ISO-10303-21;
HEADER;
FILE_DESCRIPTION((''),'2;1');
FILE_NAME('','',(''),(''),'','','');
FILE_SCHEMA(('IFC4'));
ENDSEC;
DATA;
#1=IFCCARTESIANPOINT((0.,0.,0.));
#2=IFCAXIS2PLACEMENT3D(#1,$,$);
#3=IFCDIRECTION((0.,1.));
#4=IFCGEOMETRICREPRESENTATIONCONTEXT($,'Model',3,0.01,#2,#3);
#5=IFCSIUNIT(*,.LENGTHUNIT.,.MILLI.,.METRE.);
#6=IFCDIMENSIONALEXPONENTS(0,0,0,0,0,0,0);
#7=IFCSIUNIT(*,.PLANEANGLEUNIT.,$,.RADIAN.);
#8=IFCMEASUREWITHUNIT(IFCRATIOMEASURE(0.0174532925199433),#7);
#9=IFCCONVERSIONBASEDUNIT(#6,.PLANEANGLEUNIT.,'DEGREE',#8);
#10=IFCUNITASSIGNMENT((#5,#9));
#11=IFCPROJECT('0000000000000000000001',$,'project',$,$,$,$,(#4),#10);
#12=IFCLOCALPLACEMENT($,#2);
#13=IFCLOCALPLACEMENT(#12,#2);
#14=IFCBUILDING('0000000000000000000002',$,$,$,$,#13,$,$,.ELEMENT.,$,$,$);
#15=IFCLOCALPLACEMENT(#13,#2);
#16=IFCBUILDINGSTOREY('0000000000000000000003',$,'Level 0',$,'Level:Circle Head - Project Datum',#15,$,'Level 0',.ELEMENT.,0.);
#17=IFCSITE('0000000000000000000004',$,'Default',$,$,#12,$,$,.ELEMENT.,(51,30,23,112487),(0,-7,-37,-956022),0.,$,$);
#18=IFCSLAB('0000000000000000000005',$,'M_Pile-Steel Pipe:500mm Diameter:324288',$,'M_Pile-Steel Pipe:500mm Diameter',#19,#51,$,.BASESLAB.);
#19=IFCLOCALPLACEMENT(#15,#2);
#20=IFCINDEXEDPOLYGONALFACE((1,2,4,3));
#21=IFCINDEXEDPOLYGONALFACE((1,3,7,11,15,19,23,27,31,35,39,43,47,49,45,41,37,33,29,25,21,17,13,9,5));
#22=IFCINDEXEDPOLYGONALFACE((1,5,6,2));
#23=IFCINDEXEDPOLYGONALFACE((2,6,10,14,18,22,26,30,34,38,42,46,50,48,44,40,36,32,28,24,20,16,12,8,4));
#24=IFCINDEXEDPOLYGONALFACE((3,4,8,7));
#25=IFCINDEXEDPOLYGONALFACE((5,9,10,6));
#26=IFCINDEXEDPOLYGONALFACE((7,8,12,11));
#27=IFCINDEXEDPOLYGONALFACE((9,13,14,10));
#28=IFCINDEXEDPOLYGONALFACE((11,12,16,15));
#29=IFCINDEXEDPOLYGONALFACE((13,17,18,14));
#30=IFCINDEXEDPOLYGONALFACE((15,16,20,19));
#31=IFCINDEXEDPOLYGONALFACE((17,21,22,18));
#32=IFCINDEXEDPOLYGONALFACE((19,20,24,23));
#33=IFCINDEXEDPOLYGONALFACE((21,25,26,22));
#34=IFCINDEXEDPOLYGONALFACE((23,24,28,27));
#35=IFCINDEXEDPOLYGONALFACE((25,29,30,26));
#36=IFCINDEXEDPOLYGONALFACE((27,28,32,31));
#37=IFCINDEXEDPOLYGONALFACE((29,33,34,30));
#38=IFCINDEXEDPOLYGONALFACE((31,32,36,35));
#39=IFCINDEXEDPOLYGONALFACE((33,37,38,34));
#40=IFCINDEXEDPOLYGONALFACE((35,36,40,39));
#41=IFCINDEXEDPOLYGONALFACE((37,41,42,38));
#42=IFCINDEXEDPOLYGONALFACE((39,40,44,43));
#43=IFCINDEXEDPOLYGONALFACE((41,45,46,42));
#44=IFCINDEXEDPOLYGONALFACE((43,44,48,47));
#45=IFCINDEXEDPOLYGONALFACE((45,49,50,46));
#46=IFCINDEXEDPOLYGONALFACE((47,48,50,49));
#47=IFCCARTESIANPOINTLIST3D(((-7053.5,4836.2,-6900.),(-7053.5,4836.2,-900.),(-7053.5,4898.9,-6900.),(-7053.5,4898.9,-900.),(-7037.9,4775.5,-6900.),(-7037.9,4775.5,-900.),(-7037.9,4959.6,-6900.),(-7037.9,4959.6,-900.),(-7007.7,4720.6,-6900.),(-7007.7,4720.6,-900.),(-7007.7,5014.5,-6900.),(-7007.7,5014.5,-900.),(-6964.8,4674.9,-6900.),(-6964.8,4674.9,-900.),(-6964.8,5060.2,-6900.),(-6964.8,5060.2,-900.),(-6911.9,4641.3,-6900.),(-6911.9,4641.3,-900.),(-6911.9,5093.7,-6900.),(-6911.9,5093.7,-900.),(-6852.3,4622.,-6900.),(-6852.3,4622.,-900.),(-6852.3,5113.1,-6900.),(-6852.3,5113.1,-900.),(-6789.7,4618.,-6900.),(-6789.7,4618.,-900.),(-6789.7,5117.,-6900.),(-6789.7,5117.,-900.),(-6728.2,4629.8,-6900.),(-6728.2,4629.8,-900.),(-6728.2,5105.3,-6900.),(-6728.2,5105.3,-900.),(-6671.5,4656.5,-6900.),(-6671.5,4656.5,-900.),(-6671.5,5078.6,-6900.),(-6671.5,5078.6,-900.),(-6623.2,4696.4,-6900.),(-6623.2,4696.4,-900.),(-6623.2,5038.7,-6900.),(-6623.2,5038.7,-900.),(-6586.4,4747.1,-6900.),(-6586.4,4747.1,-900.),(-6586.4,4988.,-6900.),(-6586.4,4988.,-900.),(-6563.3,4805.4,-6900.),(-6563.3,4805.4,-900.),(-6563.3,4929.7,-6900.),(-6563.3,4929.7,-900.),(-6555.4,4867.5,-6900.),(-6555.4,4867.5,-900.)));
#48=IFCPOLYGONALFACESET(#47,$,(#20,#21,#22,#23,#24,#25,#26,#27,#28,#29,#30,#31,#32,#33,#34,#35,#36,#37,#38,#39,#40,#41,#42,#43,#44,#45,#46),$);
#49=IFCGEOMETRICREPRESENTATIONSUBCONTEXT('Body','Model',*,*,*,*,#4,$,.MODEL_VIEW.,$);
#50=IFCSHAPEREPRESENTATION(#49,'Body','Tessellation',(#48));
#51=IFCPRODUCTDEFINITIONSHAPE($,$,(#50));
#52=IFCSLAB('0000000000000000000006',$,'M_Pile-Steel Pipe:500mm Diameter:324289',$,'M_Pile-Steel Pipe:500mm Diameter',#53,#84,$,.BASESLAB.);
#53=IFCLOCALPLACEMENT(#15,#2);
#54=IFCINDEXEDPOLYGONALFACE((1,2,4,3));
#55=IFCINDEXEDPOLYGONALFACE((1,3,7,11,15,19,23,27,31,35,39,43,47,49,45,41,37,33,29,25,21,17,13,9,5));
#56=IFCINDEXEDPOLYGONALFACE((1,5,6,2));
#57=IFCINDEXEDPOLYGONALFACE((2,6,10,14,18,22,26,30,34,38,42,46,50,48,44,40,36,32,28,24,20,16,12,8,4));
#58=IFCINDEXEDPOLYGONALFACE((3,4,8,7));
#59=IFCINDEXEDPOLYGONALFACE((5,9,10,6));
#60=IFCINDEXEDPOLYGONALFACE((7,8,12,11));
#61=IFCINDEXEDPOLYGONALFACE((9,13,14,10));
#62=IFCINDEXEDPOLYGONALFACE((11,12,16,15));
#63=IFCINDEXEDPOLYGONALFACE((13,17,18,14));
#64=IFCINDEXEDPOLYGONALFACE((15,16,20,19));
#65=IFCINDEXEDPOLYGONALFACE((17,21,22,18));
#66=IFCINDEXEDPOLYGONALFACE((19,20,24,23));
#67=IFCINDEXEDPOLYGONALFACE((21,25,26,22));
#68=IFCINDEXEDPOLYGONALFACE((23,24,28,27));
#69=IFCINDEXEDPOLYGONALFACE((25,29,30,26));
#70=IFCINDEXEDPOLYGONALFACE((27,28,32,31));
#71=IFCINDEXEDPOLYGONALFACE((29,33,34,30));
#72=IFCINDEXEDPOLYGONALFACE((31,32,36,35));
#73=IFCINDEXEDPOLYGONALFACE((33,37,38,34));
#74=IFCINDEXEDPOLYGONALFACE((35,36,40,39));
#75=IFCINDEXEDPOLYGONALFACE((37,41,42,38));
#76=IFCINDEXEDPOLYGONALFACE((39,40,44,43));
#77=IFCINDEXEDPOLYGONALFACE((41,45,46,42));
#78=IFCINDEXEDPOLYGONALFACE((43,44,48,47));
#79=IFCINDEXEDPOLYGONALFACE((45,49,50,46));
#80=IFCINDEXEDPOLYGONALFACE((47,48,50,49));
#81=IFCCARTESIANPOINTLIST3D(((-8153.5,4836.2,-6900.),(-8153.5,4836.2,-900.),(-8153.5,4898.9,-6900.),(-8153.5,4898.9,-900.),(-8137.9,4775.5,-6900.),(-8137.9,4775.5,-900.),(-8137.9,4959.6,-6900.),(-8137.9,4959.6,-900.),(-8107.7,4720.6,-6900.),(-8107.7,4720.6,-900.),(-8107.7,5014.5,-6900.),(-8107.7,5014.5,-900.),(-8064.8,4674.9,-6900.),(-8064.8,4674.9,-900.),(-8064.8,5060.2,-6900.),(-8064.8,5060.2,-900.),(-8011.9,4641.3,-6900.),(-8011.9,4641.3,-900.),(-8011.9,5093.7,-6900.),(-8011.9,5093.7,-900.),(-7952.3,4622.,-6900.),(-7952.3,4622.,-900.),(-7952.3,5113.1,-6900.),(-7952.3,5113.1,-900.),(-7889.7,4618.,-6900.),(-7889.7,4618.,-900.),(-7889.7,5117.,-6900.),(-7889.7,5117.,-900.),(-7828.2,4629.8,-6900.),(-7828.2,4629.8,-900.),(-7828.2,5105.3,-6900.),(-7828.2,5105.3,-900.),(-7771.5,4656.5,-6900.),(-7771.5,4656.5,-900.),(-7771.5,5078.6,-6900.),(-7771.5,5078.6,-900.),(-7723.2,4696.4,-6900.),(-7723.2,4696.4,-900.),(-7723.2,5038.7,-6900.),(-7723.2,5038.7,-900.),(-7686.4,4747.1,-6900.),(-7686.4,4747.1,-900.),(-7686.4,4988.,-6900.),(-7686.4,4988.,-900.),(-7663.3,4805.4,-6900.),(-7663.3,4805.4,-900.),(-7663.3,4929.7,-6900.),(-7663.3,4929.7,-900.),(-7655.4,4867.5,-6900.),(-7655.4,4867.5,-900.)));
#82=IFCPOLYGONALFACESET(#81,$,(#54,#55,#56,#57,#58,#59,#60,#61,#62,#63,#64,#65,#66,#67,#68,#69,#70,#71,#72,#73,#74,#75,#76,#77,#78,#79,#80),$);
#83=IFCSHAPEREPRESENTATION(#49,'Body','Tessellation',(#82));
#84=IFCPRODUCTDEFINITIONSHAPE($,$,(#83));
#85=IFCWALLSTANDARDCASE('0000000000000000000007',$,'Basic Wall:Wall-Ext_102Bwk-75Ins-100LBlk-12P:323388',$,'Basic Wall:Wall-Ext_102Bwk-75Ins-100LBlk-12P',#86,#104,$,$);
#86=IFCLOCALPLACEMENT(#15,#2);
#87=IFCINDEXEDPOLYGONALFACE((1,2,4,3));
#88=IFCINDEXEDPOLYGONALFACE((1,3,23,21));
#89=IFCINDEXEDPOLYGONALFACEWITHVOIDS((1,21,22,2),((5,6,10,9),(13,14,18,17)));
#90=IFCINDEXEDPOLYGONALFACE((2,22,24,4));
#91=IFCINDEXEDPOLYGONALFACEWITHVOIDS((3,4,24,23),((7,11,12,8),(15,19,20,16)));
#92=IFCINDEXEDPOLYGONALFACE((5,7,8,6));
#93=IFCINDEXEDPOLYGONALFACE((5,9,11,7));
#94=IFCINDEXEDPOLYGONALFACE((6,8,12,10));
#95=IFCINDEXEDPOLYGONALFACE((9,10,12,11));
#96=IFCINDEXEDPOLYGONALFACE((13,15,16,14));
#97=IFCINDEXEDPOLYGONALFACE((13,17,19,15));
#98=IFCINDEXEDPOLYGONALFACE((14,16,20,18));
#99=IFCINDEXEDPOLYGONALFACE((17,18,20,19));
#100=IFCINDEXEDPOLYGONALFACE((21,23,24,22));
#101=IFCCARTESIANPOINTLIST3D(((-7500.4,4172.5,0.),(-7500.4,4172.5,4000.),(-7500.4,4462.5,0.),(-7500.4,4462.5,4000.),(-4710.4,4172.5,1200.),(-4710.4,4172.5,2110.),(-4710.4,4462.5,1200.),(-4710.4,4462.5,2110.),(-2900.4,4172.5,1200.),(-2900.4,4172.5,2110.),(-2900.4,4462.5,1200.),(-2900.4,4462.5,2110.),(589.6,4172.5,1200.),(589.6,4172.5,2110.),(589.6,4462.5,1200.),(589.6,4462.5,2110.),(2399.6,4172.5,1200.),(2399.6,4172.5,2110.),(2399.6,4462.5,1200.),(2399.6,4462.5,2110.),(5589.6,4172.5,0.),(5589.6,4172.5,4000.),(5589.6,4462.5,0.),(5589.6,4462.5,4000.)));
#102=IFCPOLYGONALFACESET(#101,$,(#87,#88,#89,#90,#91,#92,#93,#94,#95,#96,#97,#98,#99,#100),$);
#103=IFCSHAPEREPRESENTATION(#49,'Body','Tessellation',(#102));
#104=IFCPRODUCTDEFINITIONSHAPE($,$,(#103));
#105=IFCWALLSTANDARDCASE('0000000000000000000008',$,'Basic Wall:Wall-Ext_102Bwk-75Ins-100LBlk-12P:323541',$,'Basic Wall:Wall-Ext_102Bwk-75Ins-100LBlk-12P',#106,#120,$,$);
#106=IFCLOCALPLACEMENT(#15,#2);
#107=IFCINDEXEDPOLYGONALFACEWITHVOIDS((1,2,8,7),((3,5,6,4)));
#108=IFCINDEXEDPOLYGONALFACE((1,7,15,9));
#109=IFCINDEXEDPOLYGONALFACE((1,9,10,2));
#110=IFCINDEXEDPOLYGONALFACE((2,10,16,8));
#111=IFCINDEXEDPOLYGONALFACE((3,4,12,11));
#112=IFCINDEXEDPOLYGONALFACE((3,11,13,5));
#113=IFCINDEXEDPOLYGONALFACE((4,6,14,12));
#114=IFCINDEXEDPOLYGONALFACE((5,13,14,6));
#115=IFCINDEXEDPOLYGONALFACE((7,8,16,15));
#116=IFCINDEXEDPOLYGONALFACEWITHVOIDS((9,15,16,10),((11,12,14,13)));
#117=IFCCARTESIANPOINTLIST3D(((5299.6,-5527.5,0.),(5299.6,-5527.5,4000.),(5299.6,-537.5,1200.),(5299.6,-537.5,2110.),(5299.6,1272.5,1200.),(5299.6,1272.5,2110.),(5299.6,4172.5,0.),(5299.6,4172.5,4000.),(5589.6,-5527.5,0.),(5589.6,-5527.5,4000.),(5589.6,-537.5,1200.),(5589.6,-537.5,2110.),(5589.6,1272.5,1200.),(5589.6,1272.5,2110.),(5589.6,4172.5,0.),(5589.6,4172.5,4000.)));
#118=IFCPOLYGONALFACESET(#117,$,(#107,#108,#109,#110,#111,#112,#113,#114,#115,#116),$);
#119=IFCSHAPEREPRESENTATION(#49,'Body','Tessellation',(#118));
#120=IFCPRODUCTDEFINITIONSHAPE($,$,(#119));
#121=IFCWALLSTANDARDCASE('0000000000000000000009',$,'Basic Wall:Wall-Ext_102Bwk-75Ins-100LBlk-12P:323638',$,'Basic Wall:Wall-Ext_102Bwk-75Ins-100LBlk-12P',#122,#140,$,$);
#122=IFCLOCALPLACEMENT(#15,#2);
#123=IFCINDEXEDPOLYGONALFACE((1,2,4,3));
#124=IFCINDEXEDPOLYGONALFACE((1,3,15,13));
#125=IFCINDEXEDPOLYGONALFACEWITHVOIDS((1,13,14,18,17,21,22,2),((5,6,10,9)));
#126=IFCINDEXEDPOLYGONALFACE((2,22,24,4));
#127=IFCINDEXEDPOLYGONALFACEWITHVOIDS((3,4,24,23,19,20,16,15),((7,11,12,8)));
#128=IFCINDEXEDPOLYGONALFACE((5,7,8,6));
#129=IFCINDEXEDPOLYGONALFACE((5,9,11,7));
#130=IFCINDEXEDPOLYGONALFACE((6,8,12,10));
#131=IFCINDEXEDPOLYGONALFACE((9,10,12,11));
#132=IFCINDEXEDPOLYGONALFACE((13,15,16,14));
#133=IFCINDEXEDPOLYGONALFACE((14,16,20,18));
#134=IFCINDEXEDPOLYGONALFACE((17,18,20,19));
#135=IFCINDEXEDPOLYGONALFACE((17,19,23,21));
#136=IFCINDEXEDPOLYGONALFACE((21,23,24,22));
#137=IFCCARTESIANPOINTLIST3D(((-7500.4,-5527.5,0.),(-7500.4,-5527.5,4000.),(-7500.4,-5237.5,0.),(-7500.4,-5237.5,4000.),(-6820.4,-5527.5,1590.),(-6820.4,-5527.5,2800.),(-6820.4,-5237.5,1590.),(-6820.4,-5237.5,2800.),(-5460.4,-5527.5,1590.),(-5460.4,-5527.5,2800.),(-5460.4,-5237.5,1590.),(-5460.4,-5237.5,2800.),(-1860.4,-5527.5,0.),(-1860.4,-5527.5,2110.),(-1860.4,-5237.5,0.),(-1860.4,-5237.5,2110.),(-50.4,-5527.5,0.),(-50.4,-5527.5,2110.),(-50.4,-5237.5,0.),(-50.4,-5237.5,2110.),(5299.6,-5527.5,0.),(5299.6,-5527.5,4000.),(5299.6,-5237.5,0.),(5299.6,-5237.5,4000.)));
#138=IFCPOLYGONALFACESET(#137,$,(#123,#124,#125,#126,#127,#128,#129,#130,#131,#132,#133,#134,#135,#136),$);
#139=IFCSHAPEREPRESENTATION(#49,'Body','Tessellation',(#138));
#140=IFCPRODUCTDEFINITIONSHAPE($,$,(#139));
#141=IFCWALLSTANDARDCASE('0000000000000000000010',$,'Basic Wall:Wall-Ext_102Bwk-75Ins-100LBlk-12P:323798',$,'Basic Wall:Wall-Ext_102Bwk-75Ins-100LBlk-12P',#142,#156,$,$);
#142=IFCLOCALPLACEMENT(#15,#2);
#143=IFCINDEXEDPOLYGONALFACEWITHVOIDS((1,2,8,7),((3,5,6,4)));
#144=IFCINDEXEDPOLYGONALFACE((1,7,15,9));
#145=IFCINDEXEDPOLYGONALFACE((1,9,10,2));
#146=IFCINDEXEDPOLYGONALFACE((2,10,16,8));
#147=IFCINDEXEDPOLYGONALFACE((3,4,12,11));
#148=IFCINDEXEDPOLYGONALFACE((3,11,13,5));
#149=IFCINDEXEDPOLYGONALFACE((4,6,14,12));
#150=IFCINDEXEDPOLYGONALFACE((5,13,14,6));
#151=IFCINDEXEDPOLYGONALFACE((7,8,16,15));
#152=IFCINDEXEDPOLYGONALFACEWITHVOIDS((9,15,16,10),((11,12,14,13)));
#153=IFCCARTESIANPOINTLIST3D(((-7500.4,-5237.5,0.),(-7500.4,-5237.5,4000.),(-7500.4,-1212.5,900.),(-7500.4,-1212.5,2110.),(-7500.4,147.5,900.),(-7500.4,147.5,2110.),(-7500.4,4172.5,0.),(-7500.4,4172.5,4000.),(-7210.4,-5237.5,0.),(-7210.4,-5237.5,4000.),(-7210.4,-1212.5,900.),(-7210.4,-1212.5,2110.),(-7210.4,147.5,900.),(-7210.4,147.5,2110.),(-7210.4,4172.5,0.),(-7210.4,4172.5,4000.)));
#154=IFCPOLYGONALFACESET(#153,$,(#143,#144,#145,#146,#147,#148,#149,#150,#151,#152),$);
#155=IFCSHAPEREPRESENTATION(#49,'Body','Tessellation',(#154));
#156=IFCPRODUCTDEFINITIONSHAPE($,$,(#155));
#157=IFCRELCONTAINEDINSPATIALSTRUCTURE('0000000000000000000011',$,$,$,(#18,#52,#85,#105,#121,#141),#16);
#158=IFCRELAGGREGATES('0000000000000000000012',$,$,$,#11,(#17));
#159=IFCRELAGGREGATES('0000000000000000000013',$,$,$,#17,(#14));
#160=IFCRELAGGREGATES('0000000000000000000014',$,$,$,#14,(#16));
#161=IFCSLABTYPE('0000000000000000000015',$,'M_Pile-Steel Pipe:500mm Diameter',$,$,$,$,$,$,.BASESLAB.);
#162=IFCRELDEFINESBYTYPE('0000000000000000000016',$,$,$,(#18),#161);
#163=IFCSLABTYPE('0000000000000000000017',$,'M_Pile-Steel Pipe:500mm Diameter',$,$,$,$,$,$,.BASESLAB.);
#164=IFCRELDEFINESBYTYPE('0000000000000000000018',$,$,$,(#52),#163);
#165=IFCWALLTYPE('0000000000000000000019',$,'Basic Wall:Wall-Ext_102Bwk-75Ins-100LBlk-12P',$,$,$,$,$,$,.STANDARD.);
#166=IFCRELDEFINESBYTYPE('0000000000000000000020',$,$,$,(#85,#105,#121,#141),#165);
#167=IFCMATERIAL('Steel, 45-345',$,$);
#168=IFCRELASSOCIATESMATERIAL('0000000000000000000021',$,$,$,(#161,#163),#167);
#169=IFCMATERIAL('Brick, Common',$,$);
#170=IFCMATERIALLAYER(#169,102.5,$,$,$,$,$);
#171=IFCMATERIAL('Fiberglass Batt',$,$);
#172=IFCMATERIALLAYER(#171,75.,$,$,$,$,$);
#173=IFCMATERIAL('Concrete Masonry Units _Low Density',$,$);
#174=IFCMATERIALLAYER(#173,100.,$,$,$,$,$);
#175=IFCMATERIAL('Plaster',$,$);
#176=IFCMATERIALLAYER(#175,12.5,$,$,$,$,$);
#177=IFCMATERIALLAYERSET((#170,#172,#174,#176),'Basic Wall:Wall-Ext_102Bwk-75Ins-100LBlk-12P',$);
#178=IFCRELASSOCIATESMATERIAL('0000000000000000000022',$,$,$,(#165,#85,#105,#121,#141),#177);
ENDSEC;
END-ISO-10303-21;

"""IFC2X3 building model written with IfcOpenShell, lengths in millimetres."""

from ifc_helpers import new_model, entity, si_unit, converted_unit, direction, frame, frame_2d, origin, place, context, subcontext, project, spatial, rectangle, circle, extrude, material, layer, layer_set, layer_usage, type_object, element, save


model = new_model("IFC2X3")

# Units and contexts
model_context = context("Model", 3, precision=0.01, world=origin(), true_north=direction((0.0, 1.0)))
body_context = subcontext(model_context, "Body", "Model", "MODEL_VIEW")
ifc_project = project(units=[si_unit("LENGTHUNIT", "METRE", prefix="MILLI"), converted_unit("PLANEANGLEUNIT", "DEGREE", entity("IfcRatioMeasure", 0.0174532925199433), si_unit("PLANEANGLEUNIT", "RADIAN"), dimensions=[0, 0, 0, 0, 0, 0, 0])], contexts=[model_context])

# Site, building, storey
site_placement = place(None, origin())
site = spatial("IfcSite", under=ifc_project, at=site_placement, Name="Default", CompositionType="ELEMENT", RefLatitude=(51, 30, 23, 112487), RefLongitude=(0, -7, -37, -956022), RefElevation=0.0)
building_placement = place(site_placement, origin())
building = spatial("IfcBuilding", under=site, at=building_placement, CompositionType="ELEMENT")
storey_placement = place(building_placement, origin())
storey = spatial("IfcBuildingStorey", under=building, at=storey_placement, Name="Level 0", ObjectType="Level:Circle Head - Project Datum", LongName="Level 0", CompositionType="ELEMENT", Elevation=0.0)

# Slabs
ifc_material_1 = material(Name="Steel, 45-345")
slab_type_1 = type_object("IfcSlabType", Name="M_Pile-Steel Pipe:500mm Diameter", PredefinedType="BASESLAB", material=ifc_material_1)
slab_1_placement = place(storey_placement, origin())
element("IfcSlab", 1, at=slab_1_placement, inside=storey, type_object=slab_type_1, Name="M_Pile-Steel Pipe:500mm Diameter:324288", ObjectType="M_Pile-Steel Pipe:500mm Diameter", PredefinedType="BASESLAB", context=body_context, shape_type="SweptSolid", body=[
    extrude(circle(Radius=250.0, at=frame_2d((0.0, 0.0), x_axis=(1.0, 0.0))), frame((-6805.4, 4867.5, -6900.0)), (0.0, 0.0, 1.0), 6000.0),
])
slab_type_2 = type_object("IfcSlabType", Name="M_Pile-Steel Pipe:500mm Diameter", PredefinedType="BASESLAB", material=ifc_material_1)
slab_2_placement = place(storey_placement, origin())
element("IfcSlab", 2, at=slab_2_placement, inside=storey, type_object=slab_type_2, Name="M_Pile-Steel Pipe:500mm Diameter:324289", ObjectType="M_Pile-Steel Pipe:500mm Diameter", PredefinedType="BASESLAB", context=body_context, shape_type="SweptSolid", body=[
    extrude(circle(Radius=250.0, at=frame_2d((0.0, 0.0), x_axis=(1.0, 0.0))), frame((-7905.4, 4867.5, -6900.0)), (0.0, 0.0, 1.0), 6000.0),
])

# Wall, openings
ifc_material_2 = material(Name="Brick, Common")
ifc_layer_1 = layer(ifc_material_2, 102.5)
ifc_material_3 = material(Name="Fiberglass Batt")
ifc_layer_2 = layer(ifc_material_3, 75.0)
ifc_material_4 = material(Name="Concrete Masonry Units _Low Density")
ifc_layer_3 = layer(ifc_material_4, 100.0)
ifc_material_5 = material(Name="Plaster")
ifc_layer_4 = layer(ifc_material_5, 12.5)
ifc_layer_set_1 = layer_set([ifc_layer_1, ifc_layer_2, ifc_layer_3, ifc_layer_4], Name="Basic Wall:Wall-Ext_102Bwk-75Ins-100LBlk-12P")
ifc_layer_usage_1 = layer_usage(ifc_layer_set_1, "AXIS2", "NEGATIVE", 145.0)
wall_type = type_object("IfcWallType", Name="Basic Wall:Wall-Ext_102Bwk-75Ins-100LBlk-12P", PredefinedType="STANDARD", material=ifc_layer_set_1)
wall_1_placement = place(storey_placement, frame((-7500.4, 4317.5, 0.0)))
wall_1 = element("IfcWallStandardCase", 3, at=wall_1_placement, inside=storey, type_object=wall_type, material=ifc_layer_usage_1, Name="Basic Wall:Wall-Ext_102Bwk-75Ins-100LBlk-12P:323388", ObjectType="Basic Wall:Wall-Ext_102Bwk-75Ins-100LBlk-12P", context=body_context, shape_type="SweptSolid", body=[
    extrude(rectangle(XDim=13090.0, YDim=290.0, at=frame_2d((6545.0, 0.0), x_axis=(-1.0, 0.0))), origin(), (0.0, 0.0, 1.0), 4000.0),
])
opening_1_placement = place(wall_1_placement, frame((2790.0, -145.0, 1200.0)))
element("IfcOpeningElement", 4, at=opening_1_placement, cuts=wall_1, ObjectType="Opening", context=body_context, shape_type="SweptSolid", body=[
    extrude(rectangle(XDim=910.0, YDim=1810.0, at=frame_2d((455.0, 905.0), x_axis=(-1.0, 0.0))), frame((0.0, 0.0, 0.0), z_axis=(0.0, 1.0, 0.0), x_axis=(0.0, 0.0, 1.0)), (0.0, 0.0, 1.0), 290.0),
])
opening_2_placement = place(wall_1_placement, frame((8090.0, -145.0, 1200.0)))
element("IfcOpeningElement", 5, at=opening_2_placement, cuts=wall_1, ObjectType="Opening", context=body_context, shape_type="SweptSolid", body=[
    extrude(rectangle(XDim=910.0, YDim=1810.0, at=frame_2d((455.0, 905.0), x_axis=(-1.0, 0.0))), frame((0.0, 0.0, 0.0), z_axis=(0.0, 1.0, 0.0), x_axis=(0.0, 0.0, 1.0)), (0.0, 0.0, 1.0), 290.0),
])

# Wall, opening
ifc_layer_usage_2 = layer_usage(ifc_layer_set_1, "AXIS2", "NEGATIVE", 145.0)
wall_2_placement = place(storey_placement, frame((5444.6, 4172.5, 0.0), z_axis=(0.0, 0.0, 1.0), x_axis=(0.0, -1.0, 0.0)))
wall_2 = element("IfcWallStandardCase", 6, at=wall_2_placement, inside=storey, type_object=wall_type, material=ifc_layer_usage_2, Name="Basic Wall:Wall-Ext_102Bwk-75Ins-100LBlk-12P:323541", ObjectType="Basic Wall:Wall-Ext_102Bwk-75Ins-100LBlk-12P", context=body_context, shape_type="SweptSolid", body=[
    extrude(rectangle(XDim=9700.0, YDim=290.0, at=frame_2d((4850.0, 0.0), x_axis=(-1.0, 0.0))), origin(), (0.0, 0.0, 1.0), 4000.0),
])
opening_3_placement = place(wall_2_placement, frame((2900.0, -145.0, 1200.0)))
element("IfcOpeningElement", 7, at=opening_3_placement, cuts=wall_2, ObjectType="Opening", context=body_context, shape_type="SweptSolid", body=[
    extrude(rectangle(XDim=910.0, YDim=1810.0, at=frame_2d((455.0, 905.0), x_axis=(-1.0, 0.0))), frame((0.0, 0.0, 0.0), z_axis=(0.0, 1.0, 0.0), x_axis=(0.0, 0.0, 1.0)), (0.0, 0.0, 1.0), 290.0),
])

# Wall, openings
ifc_layer_usage_3 = layer_usage(ifc_layer_set_1, "AXIS2", "NEGATIVE", 145.0)
wall_3_placement = place(storey_placement, frame((5299.6, -5382.5, 0.0), z_axis=(0.0, 0.0, 1.0), x_axis=(-1.0, 0.0, 0.0)))
wall_3 = element("IfcWallStandardCase", 8, at=wall_3_placement, inside=storey, type_object=wall_type, material=ifc_layer_usage_3, Name="Basic Wall:Wall-Ext_102Bwk-75Ins-100LBlk-12P:323638", ObjectType="Basic Wall:Wall-Ext_102Bwk-75Ins-100LBlk-12P", context=body_context, shape_type="SweptSolid", body=[
    extrude(rectangle(XDim=12800.0, YDim=290.0, at=frame_2d((6400.0, 0.0), x_axis=(-1.0, 0.0))), origin(), (0.0, 0.0, 1.0), 4000.0),
])
opening_4_placement = place(wall_3_placement, frame((7160.0, 145.0, 0.0)))
element("IfcOpeningElement", 9, at=opening_4_placement, cuts=wall_3, ObjectType="Opening", context=body_context, shape_type="SweptSolid", body=[
    extrude(rectangle(XDim=2110.0, YDim=1810.0, at=frame_2d((1055.0, 905.0), x_axis=(-1.0, 0.0))), frame((0.0, 0.0, 0.0), z_axis=(0.0, -1.0, 0.0), x_axis=(0.0, 0.0, 1.0)), (0.0, 0.0, 1.0), 290.0),
])
opening_5_placement = place(wall_3_placement, frame((10760.0, -145.0, 1590.0)))
element("IfcOpeningElement", 10, at=opening_5_placement, cuts=wall_3, ObjectType="Opening", context=body_context, shape_type="SweptSolid", body=[
    extrude(rectangle(XDim=1210.0, YDim=1360.0, at=frame_2d((605.0, 680.0), x_axis=(-1.0, 0.0))), frame((0.0, 0.0, 0.0), z_axis=(0.0, 1.0, 0.0), x_axis=(0.0, 0.0, 1.0)), (0.0, 0.0, 1.0), 290.0),
])

# Wall, opening
ifc_layer_usage_4 = layer_usage(ifc_layer_set_1, "AXIS2", "NEGATIVE", 145.0)
wall_4_placement = place(storey_placement, frame((-7355.4, -5237.5, 0.0), z_axis=(0.0, 0.0, 1.0), x_axis=(0.0, 1.0, 0.0)))
wall_4 = element("IfcWallStandardCase", 11, at=wall_4_placement, inside=storey, type_object=wall_type, material=ifc_layer_usage_4, Name="Basic Wall:Wall-Ext_102Bwk-75Ins-100LBlk-12P:323798", ObjectType="Basic Wall:Wall-Ext_102Bwk-75Ins-100LBlk-12P", context=body_context, shape_type="SweptSolid", body=[
    extrude(rectangle(XDim=9410.0, YDim=290.0, at=frame_2d((4705.0, 0.0), x_axis=(-1.0, 0.0))), origin(), (0.0, 0.0, 1.0), 4000.0),
])
opening_6_placement = place(wall_4_placement, frame((5385.0, 145.0, 900.0)))
element("IfcOpeningElement", 12, at=opening_6_placement, cuts=wall_4, ObjectType="Opening", context=body_context, shape_type="SweptSolid", body=[
    extrude(rectangle(XDim=1210.0, YDim=1360.0, at=frame_2d((605.0, 680.0), x_axis=(-1.0, 0.0))), frame((0.0, 0.0, 0.0), z_axis=(0.0, -1.0, 0.0), x_axis=(0.0, 0.0, 1.0)), (0.0, 0.0, 1.0), 290.0),
])

save(model, "model.ifc")
